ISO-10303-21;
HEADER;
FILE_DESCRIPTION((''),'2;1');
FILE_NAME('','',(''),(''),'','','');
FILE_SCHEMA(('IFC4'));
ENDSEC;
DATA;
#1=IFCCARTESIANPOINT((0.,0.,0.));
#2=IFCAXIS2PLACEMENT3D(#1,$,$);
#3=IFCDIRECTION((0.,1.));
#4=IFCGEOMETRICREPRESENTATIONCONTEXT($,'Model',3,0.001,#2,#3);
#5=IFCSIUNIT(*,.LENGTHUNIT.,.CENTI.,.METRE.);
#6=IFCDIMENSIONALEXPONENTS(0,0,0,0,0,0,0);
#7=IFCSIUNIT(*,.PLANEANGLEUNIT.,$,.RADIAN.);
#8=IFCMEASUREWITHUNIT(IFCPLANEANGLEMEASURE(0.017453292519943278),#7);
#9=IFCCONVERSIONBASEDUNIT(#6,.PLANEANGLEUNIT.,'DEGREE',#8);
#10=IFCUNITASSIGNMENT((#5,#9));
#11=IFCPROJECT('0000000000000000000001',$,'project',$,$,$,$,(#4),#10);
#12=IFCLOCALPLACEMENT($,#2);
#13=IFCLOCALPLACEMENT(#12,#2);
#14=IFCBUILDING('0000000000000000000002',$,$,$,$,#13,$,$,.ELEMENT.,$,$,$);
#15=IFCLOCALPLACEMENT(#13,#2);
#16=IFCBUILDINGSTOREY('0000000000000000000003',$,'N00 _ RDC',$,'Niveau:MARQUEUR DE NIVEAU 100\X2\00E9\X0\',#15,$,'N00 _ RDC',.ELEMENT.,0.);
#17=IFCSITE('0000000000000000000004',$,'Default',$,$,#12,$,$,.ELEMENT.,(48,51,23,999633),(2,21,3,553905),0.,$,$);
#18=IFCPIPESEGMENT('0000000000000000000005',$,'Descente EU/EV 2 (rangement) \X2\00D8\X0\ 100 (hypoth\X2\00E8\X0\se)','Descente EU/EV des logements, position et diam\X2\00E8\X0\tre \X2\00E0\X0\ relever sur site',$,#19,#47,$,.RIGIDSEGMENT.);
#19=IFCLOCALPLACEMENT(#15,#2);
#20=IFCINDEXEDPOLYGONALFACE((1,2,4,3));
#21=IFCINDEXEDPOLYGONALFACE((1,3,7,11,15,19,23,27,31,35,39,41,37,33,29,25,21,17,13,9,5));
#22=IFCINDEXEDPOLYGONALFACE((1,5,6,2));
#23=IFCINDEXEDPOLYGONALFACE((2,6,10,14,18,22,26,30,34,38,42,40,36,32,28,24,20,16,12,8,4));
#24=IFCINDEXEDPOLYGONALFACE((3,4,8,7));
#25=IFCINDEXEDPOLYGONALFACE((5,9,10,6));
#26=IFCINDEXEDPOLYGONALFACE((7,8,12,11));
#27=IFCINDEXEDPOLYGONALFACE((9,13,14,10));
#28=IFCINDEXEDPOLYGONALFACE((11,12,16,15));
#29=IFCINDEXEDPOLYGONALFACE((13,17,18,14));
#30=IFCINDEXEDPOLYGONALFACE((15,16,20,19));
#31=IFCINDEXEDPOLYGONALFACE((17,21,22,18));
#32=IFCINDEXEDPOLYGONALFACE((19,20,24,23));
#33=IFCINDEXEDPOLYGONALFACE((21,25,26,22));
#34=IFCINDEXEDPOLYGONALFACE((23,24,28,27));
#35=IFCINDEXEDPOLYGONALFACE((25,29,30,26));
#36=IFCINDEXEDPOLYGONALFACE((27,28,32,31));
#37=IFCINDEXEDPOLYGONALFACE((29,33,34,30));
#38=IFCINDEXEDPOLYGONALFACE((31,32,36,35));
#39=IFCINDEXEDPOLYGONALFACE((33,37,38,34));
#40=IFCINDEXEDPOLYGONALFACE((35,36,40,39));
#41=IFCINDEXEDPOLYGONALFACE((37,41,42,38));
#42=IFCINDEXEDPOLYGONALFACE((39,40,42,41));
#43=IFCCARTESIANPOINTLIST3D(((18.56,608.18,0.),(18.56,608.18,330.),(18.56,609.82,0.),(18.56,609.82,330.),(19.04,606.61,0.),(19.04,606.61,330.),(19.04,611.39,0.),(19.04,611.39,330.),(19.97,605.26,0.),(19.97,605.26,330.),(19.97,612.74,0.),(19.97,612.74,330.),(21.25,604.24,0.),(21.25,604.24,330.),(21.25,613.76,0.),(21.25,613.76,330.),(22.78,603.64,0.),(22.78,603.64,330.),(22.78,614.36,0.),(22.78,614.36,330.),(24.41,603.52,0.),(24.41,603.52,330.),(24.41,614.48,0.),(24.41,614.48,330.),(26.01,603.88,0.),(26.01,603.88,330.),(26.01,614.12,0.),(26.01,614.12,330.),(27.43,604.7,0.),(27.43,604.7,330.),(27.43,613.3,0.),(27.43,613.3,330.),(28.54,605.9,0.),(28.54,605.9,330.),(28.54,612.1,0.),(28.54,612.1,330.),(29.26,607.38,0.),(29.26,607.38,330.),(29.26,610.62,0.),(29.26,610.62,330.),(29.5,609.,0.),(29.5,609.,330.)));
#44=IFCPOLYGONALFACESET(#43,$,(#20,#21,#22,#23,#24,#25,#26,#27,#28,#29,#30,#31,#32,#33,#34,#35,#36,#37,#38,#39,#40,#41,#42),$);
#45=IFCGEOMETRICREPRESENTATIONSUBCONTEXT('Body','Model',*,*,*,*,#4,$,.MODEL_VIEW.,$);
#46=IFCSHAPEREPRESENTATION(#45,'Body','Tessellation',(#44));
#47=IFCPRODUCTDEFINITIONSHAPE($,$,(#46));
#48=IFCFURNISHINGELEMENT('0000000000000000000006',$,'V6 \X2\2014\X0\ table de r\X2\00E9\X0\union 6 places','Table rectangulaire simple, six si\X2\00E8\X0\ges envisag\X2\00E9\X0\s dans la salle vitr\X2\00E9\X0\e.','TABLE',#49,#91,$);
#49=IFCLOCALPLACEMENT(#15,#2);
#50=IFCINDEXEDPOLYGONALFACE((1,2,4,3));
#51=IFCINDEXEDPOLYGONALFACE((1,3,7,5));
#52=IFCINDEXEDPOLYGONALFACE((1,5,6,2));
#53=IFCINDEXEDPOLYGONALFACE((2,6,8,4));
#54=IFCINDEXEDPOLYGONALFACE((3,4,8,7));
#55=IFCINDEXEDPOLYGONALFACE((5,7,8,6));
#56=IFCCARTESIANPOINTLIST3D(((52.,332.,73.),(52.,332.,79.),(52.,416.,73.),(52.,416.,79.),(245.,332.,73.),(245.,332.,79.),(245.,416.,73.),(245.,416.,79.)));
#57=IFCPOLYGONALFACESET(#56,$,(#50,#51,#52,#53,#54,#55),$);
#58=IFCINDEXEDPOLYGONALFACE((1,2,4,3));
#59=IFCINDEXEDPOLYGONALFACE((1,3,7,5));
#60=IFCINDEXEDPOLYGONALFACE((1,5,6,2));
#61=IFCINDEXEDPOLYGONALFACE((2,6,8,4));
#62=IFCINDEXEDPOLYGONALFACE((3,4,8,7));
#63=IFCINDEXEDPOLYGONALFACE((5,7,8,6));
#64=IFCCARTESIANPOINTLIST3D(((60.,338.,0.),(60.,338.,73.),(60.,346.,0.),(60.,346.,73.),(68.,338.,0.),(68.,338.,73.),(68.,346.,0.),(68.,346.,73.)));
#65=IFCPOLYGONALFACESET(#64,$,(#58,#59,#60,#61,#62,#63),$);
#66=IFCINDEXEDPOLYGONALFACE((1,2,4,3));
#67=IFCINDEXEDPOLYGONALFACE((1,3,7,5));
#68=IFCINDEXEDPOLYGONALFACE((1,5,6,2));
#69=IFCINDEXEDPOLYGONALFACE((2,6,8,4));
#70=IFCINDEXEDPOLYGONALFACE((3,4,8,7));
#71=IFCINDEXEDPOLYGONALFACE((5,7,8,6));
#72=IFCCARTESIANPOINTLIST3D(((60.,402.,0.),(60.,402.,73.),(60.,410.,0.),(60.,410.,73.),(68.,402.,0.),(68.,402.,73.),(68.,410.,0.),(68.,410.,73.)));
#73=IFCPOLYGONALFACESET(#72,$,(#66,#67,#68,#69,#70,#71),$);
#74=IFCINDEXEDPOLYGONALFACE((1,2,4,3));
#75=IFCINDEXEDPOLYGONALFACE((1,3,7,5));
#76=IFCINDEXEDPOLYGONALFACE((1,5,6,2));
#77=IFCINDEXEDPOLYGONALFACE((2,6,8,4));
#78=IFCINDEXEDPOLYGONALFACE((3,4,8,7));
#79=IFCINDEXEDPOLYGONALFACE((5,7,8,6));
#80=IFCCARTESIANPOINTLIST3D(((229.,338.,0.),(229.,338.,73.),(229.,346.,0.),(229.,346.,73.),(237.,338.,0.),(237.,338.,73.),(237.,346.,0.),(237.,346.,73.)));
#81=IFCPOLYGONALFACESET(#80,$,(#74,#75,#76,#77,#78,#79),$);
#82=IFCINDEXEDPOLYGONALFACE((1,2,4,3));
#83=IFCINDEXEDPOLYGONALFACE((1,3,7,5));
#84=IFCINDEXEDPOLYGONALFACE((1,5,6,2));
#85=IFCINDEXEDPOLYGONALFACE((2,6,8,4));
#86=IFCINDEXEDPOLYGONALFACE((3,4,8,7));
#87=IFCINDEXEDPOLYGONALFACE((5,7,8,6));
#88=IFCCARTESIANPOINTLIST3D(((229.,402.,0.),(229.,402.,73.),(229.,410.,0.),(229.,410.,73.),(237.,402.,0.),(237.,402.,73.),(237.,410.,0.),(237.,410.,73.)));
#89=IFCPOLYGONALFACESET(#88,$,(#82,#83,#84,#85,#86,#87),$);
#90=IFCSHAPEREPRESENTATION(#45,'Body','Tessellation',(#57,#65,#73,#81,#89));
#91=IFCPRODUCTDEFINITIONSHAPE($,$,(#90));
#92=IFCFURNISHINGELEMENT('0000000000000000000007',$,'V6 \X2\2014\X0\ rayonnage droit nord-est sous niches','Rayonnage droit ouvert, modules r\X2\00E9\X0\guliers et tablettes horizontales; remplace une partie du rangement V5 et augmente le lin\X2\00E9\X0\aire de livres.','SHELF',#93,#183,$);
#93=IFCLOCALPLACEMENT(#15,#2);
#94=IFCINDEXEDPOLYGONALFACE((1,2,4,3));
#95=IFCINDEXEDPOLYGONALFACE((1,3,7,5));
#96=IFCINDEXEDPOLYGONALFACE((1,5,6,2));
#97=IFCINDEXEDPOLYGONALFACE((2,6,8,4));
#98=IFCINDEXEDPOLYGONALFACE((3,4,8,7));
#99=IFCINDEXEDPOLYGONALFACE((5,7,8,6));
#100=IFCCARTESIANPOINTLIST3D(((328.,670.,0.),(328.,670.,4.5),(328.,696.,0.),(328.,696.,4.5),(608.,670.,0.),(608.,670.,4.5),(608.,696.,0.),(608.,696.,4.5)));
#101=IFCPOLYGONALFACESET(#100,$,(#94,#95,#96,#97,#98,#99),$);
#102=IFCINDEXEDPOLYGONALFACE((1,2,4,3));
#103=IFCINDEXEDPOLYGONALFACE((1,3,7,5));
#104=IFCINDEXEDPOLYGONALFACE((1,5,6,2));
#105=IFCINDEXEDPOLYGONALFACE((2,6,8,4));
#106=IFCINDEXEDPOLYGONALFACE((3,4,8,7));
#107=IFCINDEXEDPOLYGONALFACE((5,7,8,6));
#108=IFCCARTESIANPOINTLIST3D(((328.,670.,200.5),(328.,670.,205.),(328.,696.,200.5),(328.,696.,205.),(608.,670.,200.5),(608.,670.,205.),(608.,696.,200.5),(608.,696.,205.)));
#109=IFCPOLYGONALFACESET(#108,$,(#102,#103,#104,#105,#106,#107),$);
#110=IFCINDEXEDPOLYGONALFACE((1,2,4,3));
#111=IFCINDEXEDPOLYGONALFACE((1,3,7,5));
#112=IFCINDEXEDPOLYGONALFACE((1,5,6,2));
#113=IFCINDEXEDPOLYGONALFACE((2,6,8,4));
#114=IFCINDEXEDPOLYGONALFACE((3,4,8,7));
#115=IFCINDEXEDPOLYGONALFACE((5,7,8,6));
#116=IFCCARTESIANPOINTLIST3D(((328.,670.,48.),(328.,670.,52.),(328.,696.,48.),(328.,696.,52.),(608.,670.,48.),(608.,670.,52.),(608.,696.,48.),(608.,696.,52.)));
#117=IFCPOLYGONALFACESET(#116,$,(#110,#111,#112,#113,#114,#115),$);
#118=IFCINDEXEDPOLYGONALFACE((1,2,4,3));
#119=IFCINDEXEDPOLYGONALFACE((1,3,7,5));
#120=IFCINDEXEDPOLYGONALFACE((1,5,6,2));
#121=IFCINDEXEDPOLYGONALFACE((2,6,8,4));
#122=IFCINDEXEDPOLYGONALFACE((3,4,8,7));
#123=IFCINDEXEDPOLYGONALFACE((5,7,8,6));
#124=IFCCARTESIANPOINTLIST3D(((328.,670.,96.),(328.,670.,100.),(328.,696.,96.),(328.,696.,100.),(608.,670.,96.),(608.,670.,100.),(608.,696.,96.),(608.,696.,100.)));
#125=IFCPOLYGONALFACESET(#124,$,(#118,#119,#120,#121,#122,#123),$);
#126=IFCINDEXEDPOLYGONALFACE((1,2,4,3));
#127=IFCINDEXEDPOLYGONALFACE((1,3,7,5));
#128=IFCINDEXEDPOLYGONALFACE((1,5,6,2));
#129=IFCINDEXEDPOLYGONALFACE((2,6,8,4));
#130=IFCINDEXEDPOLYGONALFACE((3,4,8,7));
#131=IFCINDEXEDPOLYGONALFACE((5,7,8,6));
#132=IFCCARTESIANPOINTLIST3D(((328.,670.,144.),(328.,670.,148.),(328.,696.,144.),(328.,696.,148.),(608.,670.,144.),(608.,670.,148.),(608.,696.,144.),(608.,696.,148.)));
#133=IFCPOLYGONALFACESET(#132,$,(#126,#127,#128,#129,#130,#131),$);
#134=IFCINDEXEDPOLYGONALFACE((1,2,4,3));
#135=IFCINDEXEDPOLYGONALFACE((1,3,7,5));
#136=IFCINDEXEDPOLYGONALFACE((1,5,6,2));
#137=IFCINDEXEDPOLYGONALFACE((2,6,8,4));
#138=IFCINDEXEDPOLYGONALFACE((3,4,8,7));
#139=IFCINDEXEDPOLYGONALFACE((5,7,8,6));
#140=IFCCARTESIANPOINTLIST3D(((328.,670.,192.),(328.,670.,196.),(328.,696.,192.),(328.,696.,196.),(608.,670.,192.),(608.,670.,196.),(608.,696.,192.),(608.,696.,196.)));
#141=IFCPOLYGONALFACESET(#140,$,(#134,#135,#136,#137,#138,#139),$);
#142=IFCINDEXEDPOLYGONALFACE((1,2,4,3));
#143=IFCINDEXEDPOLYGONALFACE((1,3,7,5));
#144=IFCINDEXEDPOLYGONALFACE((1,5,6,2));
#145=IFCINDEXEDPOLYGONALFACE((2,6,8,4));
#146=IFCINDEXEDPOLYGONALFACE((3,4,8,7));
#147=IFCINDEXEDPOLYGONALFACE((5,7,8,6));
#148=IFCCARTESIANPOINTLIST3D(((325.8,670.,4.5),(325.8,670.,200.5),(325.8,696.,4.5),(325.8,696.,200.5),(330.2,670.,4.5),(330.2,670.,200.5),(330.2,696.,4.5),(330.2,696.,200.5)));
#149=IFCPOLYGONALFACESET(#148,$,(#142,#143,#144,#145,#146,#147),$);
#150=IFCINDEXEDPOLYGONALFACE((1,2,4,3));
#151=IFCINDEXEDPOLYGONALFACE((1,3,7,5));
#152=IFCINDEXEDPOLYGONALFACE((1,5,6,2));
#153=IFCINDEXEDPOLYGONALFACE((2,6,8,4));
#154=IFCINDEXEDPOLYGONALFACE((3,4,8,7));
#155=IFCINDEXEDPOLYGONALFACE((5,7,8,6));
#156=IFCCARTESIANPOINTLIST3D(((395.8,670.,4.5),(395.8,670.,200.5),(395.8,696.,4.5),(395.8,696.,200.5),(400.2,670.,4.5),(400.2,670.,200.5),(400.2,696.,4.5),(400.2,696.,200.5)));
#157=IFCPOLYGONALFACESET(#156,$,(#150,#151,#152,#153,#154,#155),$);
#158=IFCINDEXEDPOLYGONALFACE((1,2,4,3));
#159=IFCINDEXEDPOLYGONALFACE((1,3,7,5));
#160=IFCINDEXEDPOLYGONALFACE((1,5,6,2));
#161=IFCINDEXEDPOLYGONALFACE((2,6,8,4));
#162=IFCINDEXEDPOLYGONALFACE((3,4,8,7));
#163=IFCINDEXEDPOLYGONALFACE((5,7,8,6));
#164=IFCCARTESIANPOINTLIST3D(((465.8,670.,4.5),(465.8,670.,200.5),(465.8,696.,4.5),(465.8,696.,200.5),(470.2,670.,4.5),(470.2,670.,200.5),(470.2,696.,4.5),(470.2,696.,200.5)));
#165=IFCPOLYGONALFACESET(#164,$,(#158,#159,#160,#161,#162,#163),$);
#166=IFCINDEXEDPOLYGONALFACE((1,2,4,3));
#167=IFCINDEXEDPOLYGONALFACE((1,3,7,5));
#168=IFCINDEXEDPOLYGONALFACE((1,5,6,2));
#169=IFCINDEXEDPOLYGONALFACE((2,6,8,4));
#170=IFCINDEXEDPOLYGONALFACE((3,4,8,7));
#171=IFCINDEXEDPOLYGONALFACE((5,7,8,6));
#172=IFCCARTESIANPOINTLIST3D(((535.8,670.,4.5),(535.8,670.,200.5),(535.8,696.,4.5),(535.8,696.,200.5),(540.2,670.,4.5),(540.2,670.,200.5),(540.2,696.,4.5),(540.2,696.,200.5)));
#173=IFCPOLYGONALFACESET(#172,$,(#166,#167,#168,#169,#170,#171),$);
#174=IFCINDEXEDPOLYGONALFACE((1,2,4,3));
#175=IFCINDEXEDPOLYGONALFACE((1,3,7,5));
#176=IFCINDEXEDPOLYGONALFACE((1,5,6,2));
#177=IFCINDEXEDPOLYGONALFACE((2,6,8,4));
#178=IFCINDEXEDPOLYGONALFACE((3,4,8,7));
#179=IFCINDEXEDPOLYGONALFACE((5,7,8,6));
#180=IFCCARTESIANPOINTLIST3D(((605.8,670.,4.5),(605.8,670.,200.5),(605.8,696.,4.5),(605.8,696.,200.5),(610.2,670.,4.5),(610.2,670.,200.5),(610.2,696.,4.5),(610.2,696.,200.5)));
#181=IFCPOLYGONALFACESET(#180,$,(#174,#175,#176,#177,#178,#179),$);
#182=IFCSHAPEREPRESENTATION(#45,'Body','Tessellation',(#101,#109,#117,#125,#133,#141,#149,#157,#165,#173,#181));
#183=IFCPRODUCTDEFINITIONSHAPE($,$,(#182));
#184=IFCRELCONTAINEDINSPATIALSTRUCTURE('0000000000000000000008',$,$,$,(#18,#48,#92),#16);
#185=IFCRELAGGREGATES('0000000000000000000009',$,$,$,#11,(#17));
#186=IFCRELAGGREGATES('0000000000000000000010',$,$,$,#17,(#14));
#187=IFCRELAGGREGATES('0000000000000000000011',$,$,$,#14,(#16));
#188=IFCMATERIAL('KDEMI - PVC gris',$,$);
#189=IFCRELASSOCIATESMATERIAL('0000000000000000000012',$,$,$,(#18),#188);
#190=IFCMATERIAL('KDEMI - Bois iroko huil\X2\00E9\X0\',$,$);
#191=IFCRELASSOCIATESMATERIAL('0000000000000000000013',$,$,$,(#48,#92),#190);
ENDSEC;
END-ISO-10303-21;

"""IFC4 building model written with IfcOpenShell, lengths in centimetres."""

from ifc_helpers import new_model, entity, si_unit, converted_unit, direction, frame, frame_2d, origin, origin_with_axes, place, context, subcontext, project, spatial, rectangle, circle, extrude, material, element, save


model = new_model("IFC4")

# Units and contexts
model_context = context("Model", 3, precision=0.001, world=origin(), true_north=direction((0.0, 1.0)))
body_context = subcontext(model_context, "Body", "Model", "MODEL_VIEW")
ifc_project = project(units=[si_unit("LENGTHUNIT", "METRE", prefix="CENTI"), converted_unit("PLANEANGLEUNIT", "DEGREE", entity("IfcPlaneAngleMeasure", 0.017453292519943278), si_unit("PLANEANGLEUNIT", "RADIAN"), dimensions=[0, 0, 0, 0, 0, 0, 0])], contexts=[model_context])

# Site, building, storey
site_placement = place(None, origin())
site = spatial("IfcSite", under=ifc_project, at=site_placement, Name="Default", CompositionType="ELEMENT", RefLatitude=(48, 51, 23, 999633), RefLongitude=(2, 21, 3, 553905), RefElevation=0.0)
building_placement = place(site_placement, origin())
building = spatial("IfcBuilding", under=site, at=building_placement, CompositionType="ELEMENT")
storey_placement = place(building_placement, origin())
storey = spatial("IfcBuildingStorey", under=building, at=storey_placement, Name="N00 _ RDC", ObjectType="Niveau:MARQUEUR DE NIVEAU 100é", LongName="N00 _ RDC", CompositionType="ELEMENT", Elevation=0.0)

# Shared definitions
ifc_material_1 = material(Name="KDEMI - PVC gris")

# Pipe segment
pipe_segment_1_placement = place(storey_placement, origin_with_axes())
element("IfcPipeSegment", 1, at=pipe_segment_1_placement, inside=storey, material=ifc_material_1, Name="Descente EU/EV 2 (rangement) Ø 100 (hypothèse)", Description="Descente EU/EV des logements, position et diamètre à relever sur site", PredefinedType="RIGIDSEGMENT", context=body_context, shape_type="SweptSolid", body=[
    extrude(circle(Radius=5.5, at=frame_2d((24.0, 609.0))), origin(), (0.0, 0.0, 1.0), 330.0),
])

# Furnishing elements
ifc_material_2 = material(Name="KDEMI - Bois iroko huilé")
furnishing_1_placement = place(storey_placement, origin_with_axes())
element("IfcFurnishingElement", 2, at=furnishing_1_placement, inside=storey, material=ifc_material_2, Name="V6 — table de réunion 6 places", Description="Table rectangulaire simple, six sièges envisagés dans la salle vitrée.", ObjectType="TABLE", context=body_context, shape_type="SweptSolid", body=[
    extrude(rectangle(XDim=193.0, YDim=84.0, at=frame_2d((148.5, 374.0))), frame((0.0, 0.0, 73.0)), (0.0, 0.0, 1.0), 6.0),
    extrude(rectangle(XDim=8.0, YDim=8.0, at=frame_2d((64.0, 342.0))), origin(), (0.0, 0.0, 1.0), 73.0),
    extrude(rectangle(XDim=8.0, YDim=8.0, at=frame_2d((64.0, 406.0))), origin(), (0.0, 0.0, 1.0), 73.0),
    extrude(rectangle(XDim=8.0, YDim=8.0, at=frame_2d((233.0, 342.0))), origin(), (0.0, 0.0, 1.0), 73.0),
    extrude(rectangle(XDim=8.0, YDim=8.0, at=frame_2d((233.0, 406.0))), origin(), (0.0, 0.0, 1.0), 73.0),
])
furnishing_2_placement = place(storey_placement, origin_with_axes())
element("IfcFurnishingElement", 3, at=furnishing_2_placement, inside=storey, material=ifc_material_2, Name="V6 — rayonnage droit nord-est sous niches", Description="Rayonnage droit ouvert, modules réguliers et tablettes horizontales; remplace une partie du rangement V5 et augmente le linéaire de livres.", ObjectType="SHELF", context=body_context, shape_type="SweptSolid", body=[
    extrude(rectangle(XDim=280.0, YDim=26.0, at=frame_2d((468.0, 683.0))), origin(), (0.0, 0.0, 1.0), 4.5),
    extrude(rectangle(XDim=280.0, YDim=26.0, at=frame_2d((468.0, 683.0))), frame((0.0, 0.0, 200.5)), (0.0, 0.0, 1.0), 4.5),
    extrude(rectangle(XDim=280.0, YDim=26.0, at=frame_2d((468.0, 683.0))), frame((0.0, 0.0, 48.0)), (0.0, 0.0, 1.0), 4.0),
    extrude(rectangle(XDim=280.0, YDim=26.0, at=frame_2d((468.0, 683.0))), frame((0.0, 0.0, 96.0)), (0.0, 0.0, 1.0), 4.0),
    extrude(rectangle(XDim=280.0, YDim=26.0, at=frame_2d((468.0, 683.0))), frame((0.0, 0.0, 144.0)), (0.0, 0.0, 1.0), 4.0),
    extrude(rectangle(XDim=280.0, YDim=26.0, at=frame_2d((468.0, 683.0))), frame((0.0, 0.0, 192.0)), (0.0, 0.0, 1.0), 4.0),
    extrude(rectangle(XDim=4.4, YDim=26.0, at=frame_2d((328.0, 683.0))), frame((0.0, 0.0, 4.5)), (0.0, 0.0, 1.0), 196.0),
    extrude(rectangle(XDim=4.4, YDim=26.0, at=frame_2d((398.0, 683.0))), frame((0.0, 0.0, 4.5)), (0.0, 0.0, 1.0), 196.0),
    extrude(rectangle(XDim=4.4, YDim=26.0, at=frame_2d((468.0, 683.0))), frame((0.0, 0.0, 4.5)), (0.0, 0.0, 1.0), 196.0),
    extrude(rectangle(XDim=4.4, YDim=26.0, at=frame_2d((538.0, 683.0))), frame((0.0, 0.0, 4.5)), (0.0, 0.0, 1.0), 196.0),
    extrude(rectangle(XDim=4.4, YDim=26.0, at=frame_2d((608.0, 683.0))), frame((0.0, 0.0, 4.5)), (0.0, 0.0, 1.0), 196.0),
])

save(model, "model.ifc")
